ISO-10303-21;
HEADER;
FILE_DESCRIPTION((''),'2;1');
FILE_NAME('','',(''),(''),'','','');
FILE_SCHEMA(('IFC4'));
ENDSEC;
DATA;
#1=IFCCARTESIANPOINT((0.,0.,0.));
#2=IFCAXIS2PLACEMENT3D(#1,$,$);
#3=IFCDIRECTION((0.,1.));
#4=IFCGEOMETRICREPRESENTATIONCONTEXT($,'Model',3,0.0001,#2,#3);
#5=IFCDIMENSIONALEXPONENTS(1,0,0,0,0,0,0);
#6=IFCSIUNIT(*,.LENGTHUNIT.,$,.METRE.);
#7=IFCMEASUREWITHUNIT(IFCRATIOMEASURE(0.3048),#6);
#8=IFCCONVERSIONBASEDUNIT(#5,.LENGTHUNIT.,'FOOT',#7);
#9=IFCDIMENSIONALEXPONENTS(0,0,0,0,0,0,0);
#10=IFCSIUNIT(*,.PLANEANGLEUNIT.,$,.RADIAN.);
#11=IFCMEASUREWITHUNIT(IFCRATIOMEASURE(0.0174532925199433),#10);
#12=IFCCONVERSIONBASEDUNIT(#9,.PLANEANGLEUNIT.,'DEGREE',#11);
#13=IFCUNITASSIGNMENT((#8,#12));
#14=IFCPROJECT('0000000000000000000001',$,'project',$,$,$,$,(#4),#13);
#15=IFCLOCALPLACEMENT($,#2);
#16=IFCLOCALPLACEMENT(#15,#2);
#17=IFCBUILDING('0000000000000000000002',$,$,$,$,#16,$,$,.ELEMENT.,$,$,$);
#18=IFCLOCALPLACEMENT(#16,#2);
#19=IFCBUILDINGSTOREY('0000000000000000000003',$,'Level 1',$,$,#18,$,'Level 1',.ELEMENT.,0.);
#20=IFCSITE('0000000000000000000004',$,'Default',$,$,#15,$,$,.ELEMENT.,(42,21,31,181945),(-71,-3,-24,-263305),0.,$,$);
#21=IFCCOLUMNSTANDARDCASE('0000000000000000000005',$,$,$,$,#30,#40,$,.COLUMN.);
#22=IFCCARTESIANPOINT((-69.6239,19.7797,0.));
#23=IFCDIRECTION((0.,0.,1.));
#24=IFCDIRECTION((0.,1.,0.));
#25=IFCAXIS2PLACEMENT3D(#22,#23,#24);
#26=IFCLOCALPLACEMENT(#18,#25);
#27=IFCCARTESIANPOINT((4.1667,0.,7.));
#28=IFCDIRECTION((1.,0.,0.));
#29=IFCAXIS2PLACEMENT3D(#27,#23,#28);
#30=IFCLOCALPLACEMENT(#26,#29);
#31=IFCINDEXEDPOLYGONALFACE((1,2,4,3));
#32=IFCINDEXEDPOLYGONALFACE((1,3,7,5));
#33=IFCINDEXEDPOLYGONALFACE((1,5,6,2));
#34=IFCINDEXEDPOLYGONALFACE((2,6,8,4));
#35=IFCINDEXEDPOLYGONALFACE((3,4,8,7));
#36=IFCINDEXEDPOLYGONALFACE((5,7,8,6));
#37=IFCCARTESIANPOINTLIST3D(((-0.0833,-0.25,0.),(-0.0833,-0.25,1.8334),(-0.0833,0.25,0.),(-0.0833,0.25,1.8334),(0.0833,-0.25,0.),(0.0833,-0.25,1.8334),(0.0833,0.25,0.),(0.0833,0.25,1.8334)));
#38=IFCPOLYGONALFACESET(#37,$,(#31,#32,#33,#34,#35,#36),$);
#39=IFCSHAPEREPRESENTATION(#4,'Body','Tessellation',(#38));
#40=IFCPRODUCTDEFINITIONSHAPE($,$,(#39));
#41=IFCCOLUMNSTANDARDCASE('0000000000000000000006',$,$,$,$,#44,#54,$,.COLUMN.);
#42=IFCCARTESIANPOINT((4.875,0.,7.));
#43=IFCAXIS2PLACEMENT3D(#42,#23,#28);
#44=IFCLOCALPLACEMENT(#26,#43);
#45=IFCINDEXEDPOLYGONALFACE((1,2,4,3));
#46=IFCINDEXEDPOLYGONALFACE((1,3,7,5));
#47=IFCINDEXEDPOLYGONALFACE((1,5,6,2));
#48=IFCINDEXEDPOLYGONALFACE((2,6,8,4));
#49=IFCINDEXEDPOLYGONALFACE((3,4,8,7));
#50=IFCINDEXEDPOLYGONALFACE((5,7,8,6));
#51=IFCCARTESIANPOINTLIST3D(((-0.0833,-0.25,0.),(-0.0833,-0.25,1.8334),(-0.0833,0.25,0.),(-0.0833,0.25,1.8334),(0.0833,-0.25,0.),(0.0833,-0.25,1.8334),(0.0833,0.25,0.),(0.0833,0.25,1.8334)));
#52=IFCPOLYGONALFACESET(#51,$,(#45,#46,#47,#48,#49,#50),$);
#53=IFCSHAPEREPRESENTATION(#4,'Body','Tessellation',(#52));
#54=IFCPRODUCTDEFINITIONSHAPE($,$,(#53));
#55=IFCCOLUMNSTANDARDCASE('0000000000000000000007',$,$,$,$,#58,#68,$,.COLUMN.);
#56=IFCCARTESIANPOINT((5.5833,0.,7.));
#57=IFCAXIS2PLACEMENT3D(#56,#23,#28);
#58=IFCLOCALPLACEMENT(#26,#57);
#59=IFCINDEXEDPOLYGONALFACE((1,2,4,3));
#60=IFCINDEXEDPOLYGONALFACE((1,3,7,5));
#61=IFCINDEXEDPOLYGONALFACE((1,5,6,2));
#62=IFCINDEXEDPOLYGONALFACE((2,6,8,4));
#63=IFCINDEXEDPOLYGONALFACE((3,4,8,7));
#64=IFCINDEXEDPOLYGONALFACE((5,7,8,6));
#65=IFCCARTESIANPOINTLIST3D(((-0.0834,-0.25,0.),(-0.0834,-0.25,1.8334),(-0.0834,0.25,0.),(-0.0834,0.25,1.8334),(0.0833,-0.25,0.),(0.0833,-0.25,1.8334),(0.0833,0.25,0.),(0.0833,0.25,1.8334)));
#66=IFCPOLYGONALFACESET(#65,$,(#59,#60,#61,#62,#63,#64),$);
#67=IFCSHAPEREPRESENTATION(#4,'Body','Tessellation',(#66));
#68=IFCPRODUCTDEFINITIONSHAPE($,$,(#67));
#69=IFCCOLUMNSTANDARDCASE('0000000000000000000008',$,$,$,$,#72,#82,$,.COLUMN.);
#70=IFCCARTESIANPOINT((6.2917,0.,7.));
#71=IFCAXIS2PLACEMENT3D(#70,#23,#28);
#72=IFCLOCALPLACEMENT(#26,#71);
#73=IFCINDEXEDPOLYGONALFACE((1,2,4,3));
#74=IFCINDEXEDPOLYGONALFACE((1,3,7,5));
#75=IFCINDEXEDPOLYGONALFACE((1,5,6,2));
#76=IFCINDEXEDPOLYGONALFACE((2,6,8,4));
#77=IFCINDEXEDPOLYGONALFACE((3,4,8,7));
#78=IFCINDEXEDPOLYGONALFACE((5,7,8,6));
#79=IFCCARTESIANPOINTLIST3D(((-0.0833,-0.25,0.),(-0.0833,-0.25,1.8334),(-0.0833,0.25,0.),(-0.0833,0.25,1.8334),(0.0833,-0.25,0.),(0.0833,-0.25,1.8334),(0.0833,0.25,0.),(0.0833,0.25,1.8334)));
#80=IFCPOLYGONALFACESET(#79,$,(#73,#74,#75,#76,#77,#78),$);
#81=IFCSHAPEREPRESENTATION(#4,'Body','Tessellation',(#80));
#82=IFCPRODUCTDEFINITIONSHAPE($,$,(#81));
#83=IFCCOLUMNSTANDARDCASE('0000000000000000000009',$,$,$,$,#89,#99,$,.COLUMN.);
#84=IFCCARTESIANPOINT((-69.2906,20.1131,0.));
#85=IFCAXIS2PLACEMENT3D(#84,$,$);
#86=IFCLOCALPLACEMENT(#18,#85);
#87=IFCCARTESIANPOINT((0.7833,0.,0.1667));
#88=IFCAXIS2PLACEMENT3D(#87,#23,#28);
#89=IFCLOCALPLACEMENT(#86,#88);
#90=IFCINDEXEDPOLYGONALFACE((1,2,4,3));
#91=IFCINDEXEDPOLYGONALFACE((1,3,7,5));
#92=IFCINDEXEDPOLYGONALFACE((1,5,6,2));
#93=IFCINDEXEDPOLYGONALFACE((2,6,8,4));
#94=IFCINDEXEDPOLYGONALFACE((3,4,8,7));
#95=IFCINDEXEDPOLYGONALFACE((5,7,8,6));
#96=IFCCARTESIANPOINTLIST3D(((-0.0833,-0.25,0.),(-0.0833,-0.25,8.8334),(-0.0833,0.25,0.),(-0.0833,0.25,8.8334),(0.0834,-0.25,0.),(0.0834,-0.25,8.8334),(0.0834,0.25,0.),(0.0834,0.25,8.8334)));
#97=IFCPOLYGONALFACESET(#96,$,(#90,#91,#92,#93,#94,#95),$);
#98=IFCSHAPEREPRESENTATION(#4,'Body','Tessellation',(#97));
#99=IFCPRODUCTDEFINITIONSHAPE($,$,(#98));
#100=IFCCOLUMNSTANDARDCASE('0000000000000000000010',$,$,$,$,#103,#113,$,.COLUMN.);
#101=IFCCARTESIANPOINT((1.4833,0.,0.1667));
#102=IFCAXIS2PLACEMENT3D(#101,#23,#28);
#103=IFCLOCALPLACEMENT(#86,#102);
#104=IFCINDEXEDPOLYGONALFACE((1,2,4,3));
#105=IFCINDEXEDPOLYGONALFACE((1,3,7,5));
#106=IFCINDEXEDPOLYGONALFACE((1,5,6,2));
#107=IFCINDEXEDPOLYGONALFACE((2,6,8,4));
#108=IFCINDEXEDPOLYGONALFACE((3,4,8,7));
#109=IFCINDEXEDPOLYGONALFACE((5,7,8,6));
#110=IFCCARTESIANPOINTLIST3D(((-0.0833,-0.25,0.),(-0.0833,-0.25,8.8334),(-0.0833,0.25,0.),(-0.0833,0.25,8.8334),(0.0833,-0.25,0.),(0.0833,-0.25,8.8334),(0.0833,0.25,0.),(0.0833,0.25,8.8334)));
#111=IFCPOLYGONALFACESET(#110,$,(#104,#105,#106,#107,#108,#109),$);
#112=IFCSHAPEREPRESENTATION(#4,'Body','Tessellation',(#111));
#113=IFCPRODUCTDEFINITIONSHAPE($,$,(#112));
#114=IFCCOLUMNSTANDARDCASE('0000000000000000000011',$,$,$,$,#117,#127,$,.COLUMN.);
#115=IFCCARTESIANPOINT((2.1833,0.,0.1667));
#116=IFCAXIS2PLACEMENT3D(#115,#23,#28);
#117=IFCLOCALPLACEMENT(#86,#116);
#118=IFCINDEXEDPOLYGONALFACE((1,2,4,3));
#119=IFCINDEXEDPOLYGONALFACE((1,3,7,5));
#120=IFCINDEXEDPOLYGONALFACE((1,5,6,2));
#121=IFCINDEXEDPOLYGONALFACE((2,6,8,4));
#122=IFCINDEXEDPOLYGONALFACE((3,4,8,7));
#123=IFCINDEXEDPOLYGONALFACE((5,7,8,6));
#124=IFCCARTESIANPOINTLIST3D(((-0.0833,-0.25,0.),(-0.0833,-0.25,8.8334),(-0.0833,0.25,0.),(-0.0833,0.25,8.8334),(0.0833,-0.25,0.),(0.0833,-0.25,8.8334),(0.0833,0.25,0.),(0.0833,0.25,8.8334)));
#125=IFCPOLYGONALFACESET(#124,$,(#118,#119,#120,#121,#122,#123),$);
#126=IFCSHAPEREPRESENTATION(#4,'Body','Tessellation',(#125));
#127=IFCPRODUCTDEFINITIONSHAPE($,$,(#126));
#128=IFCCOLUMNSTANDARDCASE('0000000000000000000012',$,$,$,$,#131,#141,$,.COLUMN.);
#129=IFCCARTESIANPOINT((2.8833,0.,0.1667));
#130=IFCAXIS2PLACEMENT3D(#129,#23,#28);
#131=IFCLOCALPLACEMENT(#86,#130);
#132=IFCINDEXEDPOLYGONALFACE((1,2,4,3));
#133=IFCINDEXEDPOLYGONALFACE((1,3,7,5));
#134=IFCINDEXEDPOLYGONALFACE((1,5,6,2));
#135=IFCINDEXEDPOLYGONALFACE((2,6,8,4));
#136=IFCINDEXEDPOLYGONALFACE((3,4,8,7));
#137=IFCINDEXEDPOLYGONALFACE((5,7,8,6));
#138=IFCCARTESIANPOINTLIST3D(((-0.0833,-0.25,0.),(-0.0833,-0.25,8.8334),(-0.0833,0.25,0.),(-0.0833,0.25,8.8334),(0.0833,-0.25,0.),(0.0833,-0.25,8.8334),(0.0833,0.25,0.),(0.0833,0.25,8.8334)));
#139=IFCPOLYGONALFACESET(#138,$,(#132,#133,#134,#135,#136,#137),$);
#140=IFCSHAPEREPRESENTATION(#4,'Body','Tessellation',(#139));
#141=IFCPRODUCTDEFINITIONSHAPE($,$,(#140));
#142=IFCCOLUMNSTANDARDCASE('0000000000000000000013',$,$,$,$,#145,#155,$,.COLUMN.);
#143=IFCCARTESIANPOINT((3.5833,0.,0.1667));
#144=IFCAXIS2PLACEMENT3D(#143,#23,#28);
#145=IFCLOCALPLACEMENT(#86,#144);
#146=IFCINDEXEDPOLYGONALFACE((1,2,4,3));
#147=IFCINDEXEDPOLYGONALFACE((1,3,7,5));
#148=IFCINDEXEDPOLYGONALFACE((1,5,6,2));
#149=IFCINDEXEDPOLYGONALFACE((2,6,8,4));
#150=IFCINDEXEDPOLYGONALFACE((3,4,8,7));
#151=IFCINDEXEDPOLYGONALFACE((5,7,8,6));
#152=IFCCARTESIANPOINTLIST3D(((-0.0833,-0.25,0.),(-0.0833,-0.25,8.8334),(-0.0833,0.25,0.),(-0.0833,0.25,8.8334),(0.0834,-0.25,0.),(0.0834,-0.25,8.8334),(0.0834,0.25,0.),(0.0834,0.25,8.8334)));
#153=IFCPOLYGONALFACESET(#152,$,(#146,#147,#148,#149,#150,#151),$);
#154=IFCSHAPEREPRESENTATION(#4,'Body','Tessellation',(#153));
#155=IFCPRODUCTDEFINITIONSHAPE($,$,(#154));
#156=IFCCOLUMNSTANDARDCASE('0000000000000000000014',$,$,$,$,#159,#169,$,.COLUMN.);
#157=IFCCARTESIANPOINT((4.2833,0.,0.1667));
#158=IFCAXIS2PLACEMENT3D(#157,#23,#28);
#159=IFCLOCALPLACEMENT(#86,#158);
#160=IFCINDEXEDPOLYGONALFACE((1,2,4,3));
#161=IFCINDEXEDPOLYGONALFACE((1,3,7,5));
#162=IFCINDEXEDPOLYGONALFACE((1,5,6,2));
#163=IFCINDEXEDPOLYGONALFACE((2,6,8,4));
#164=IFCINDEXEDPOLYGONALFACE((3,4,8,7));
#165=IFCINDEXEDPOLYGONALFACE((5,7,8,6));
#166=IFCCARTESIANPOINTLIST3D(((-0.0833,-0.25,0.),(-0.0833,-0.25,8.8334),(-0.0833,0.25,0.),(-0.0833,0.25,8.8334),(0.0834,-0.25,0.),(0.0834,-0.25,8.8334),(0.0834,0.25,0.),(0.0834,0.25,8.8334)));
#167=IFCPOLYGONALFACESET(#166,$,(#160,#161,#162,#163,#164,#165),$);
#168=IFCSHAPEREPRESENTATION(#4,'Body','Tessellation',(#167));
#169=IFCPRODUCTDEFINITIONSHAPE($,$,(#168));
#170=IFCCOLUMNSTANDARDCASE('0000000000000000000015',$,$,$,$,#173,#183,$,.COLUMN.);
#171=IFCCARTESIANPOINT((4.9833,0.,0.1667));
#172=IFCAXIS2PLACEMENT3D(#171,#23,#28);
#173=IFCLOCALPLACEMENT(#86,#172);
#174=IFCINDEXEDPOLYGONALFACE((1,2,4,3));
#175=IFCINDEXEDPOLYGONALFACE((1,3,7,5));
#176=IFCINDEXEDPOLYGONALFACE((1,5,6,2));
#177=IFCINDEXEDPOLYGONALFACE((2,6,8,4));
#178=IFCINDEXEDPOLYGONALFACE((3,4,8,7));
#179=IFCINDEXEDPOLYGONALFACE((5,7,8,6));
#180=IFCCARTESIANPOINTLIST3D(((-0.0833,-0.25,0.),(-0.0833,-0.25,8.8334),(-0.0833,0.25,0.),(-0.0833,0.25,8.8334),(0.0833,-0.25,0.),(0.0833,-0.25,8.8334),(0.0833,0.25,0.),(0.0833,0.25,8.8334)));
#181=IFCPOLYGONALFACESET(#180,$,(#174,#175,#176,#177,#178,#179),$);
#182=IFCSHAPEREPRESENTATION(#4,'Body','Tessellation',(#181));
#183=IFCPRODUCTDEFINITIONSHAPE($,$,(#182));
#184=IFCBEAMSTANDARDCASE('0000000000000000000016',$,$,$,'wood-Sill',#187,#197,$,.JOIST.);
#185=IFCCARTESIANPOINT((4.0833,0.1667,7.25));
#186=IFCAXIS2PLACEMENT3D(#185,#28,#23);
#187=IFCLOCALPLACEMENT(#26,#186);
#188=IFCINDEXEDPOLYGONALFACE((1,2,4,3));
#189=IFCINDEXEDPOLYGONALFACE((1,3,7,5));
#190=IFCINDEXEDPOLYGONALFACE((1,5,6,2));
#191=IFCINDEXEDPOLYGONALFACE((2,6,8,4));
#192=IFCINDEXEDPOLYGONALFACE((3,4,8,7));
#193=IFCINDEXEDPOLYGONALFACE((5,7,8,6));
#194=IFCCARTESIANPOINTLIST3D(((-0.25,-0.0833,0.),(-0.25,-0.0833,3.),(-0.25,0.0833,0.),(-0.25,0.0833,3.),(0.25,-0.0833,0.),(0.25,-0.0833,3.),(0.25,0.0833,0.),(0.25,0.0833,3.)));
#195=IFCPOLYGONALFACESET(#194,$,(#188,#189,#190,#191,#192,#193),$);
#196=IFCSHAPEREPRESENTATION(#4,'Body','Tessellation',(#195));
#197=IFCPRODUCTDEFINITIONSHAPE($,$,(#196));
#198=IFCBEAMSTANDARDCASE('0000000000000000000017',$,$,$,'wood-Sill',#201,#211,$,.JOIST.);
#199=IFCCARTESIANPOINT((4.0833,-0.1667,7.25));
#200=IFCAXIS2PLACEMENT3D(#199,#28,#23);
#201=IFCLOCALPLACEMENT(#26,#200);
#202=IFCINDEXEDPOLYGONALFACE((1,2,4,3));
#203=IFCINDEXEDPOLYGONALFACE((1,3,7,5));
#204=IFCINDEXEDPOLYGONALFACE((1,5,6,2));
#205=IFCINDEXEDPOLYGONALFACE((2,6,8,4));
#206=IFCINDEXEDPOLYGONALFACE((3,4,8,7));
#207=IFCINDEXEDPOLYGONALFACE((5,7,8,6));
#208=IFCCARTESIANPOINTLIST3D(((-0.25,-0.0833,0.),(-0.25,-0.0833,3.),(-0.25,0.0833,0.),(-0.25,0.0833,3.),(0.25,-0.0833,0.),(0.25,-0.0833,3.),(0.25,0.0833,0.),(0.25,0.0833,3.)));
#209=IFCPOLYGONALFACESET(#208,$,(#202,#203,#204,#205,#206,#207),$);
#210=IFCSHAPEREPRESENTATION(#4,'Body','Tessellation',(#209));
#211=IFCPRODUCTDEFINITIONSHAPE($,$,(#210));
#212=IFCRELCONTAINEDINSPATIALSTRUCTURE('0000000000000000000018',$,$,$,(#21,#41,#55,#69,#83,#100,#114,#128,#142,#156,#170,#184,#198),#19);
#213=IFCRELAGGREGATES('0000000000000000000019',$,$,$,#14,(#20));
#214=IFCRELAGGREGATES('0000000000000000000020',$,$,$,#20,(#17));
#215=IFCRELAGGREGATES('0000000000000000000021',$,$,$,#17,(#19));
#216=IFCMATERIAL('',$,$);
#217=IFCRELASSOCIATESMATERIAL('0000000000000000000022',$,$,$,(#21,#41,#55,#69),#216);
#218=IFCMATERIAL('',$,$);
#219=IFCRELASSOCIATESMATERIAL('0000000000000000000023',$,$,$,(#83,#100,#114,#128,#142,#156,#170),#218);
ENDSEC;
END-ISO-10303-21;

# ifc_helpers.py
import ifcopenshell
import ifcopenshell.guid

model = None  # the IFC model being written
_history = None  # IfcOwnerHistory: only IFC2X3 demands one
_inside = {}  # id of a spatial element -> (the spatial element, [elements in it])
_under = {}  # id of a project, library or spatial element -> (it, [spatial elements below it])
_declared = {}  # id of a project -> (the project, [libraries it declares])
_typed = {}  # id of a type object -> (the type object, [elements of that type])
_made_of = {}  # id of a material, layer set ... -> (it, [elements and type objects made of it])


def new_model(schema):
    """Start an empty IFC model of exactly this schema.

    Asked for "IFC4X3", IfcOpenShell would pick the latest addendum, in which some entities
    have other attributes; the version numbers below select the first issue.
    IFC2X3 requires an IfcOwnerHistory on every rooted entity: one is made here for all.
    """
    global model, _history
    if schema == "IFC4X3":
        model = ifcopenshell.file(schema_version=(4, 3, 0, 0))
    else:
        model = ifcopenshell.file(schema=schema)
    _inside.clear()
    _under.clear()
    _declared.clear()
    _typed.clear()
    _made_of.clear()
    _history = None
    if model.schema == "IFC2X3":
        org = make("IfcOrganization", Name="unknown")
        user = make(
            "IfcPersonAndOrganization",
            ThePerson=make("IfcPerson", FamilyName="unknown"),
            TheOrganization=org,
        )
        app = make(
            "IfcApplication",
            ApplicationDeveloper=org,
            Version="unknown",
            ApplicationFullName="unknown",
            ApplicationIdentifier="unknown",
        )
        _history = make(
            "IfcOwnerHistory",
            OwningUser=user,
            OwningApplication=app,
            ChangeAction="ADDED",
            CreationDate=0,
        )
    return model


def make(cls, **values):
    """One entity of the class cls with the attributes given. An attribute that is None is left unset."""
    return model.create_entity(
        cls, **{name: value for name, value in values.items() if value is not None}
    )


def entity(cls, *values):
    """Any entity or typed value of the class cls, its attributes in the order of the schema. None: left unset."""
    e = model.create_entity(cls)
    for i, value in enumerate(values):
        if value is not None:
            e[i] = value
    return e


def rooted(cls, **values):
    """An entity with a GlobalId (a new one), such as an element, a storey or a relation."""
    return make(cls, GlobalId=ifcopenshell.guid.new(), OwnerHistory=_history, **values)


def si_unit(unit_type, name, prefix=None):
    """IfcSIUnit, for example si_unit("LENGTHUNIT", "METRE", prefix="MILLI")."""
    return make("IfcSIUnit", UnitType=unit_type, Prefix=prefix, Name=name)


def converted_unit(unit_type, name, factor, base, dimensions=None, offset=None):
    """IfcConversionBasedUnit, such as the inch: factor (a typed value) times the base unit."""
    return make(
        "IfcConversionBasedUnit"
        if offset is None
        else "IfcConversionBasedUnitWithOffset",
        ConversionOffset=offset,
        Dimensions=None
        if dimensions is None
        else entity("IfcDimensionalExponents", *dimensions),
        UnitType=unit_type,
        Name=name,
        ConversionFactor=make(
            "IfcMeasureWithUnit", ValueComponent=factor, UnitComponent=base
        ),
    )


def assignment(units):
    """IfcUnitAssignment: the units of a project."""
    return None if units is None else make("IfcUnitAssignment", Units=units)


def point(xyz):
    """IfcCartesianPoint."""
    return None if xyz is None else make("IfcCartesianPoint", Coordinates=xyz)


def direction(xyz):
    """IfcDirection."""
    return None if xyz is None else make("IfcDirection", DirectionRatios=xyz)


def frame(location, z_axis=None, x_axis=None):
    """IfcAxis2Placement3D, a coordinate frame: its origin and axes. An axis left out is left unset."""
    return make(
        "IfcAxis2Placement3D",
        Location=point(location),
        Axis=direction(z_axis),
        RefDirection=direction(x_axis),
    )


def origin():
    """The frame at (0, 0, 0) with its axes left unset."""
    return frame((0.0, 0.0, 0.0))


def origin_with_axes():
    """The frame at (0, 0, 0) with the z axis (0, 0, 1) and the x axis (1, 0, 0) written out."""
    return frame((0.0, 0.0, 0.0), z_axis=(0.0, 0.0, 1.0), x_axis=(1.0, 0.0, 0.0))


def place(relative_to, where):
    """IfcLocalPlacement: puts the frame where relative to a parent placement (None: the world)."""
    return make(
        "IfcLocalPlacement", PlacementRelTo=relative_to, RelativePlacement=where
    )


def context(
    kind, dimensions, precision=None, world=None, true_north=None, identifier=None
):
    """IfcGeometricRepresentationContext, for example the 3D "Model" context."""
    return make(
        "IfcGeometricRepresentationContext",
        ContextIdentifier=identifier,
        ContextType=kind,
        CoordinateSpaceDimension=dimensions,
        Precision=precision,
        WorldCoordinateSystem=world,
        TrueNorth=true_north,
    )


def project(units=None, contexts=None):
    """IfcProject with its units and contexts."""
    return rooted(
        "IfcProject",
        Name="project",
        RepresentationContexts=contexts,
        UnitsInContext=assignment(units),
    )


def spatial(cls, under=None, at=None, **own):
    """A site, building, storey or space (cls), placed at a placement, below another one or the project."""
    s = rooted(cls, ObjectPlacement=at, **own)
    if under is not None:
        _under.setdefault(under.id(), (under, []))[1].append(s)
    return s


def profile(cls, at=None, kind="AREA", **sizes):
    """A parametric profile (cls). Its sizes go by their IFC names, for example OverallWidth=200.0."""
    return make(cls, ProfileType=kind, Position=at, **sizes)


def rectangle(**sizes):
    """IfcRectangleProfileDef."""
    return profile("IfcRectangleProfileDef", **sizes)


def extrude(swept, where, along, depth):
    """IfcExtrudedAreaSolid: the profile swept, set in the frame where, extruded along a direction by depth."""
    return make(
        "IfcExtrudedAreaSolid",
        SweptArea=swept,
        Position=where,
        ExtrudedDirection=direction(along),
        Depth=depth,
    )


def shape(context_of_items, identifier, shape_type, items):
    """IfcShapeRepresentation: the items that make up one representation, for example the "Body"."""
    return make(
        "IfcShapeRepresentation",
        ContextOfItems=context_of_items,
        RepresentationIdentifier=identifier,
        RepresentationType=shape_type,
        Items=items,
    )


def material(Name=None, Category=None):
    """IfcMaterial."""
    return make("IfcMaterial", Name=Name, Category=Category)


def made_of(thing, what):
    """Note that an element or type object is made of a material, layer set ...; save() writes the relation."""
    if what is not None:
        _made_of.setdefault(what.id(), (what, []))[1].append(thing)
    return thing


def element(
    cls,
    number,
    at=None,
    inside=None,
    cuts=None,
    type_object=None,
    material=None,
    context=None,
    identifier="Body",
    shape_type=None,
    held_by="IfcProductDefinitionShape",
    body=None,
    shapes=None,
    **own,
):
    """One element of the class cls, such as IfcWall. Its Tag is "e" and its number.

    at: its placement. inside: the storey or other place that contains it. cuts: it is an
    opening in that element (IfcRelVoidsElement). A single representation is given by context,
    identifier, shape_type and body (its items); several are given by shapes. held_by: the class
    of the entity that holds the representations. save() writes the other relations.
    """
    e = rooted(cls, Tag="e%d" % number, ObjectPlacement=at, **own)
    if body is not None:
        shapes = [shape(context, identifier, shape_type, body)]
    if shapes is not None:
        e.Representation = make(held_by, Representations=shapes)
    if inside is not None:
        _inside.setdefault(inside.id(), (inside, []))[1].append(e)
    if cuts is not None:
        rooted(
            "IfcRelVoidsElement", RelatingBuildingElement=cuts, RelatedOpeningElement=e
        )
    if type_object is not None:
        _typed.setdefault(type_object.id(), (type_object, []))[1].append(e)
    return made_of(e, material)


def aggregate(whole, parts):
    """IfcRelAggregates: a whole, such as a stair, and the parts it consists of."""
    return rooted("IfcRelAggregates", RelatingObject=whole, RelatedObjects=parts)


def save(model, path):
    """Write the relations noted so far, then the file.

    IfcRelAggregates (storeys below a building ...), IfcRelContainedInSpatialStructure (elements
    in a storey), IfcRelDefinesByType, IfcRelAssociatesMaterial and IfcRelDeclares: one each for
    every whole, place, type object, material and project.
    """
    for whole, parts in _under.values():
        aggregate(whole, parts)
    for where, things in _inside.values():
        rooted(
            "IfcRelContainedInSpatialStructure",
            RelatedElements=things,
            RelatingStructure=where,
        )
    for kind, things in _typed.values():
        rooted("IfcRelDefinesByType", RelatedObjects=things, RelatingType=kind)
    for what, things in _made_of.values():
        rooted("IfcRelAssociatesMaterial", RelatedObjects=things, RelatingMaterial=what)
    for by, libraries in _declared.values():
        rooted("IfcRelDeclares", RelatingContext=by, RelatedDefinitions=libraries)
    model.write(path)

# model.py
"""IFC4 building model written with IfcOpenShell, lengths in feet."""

from ifc_helpers import new_model, entity, si_unit, converted_unit, direction, frame, origin, origin_with_axes, place, context, project, spatial, rectangle, extrude, material, element, save


model = new_model("IFC4")

# Units and contexts
model_context = context("Model", 3, precision=0.0001, world=origin(), true_north=direction((0.0, 1.0)))
ifc_project = project(units=[converted_unit("LENGTHUNIT", "FOOT", entity("IfcRatioMeasure", 0.3048), si_unit("LENGTHUNIT", "METRE"), dimensions=[1, 0, 0, 0, 0, 0, 0]), converted_unit("PLANEANGLEUNIT", "DEGREE", entity("IfcRatioMeasure", 0.0174532925199433), si_unit("PLANEANGLEUNIT", "RADIAN"), dimensions=[0, 0, 0, 0, 0, 0, 0])], contexts=[model_context])

# Site, building, storey
site_placement = place(None, origin())
site = spatial("IfcSite", under=ifc_project, at=site_placement, Name="Default", CompositionType="ELEMENT", RefLatitude=(42, 21, 31, 181945), RefLongitude=(-71, -3, -24, -263305), RefElevation=0.0)
building_placement = place(site_placement, origin())
building = spatial("IfcBuilding", under=site, at=building_placement, CompositionType="ELEMENT")
storey_placement = place(building_placement, origin())
storey = spatial("IfcBuildingStorey", under=building, at=storey_placement, Name="Level 1", LongName="Level 1", CompositionType="ELEMENT", Elevation=0.0)

# Columns
ifc_material_1 = material(Name="")
placement_1 = place(storey_placement, frame((-69.6239, 19.7797, 0.0), z_axis=(0.0, 0.0, 1.0), x_axis=(0.0, 1.0, 0.0)))
ifc_material_2 = material(Name="")
for number, where, z_axis, x_axis in (
    (1, (4.1667, 0.0, 7.0), (0.0, 0.0, 1.0), (1.0, 0.0, 0.0)),
    (2, (4.875, 0.0, 7.0), (0.0, 0.0, 1.0), (1.0, 0.0, 0.0)),
    (3, (5.5833, 0.0, 7.0), (0.0, 0.0, 1.0), (1.0, 0.0, 0.0)),
    (4, (6.2917, 0.0, 7.0), (0.0, 0.0, 1.0), (1.0, 0.0, 0.0)),
):
    element("IfcColumnStandardCase", number, at=place(placement_1, frame(where, z_axis=z_axis, x_axis=x_axis)), inside=storey, material=ifc_material_2, PredefinedType="COLUMN", context=model_context, shape_type="SweptSolid", body=[
        extrude(rectangle(XDim=0.1667, YDim=0.5), origin(), (0.0, 0.0, 1.0), 1.8334),
    ])
placement_2 = place(storey_placement, frame((-69.2906, 20.1131, 0.0)))
for number, where, z_axis, x_axis in (
    (5, (0.7833, 0.0, 0.1667), (0.0, 0.0, 1.0), (1.0, 0.0, 0.0)),
    (6, (1.4833, 0.0, 0.1667), (0.0, 0.0, 1.0), (1.0, 0.0, 0.0)),
    (7, (2.1833, 0.0, 0.1667), (0.0, 0.0, 1.0), (1.0, 0.0, 0.0)),
    (8, (2.8833, 0.0, 0.1667), (0.0, 0.0, 1.0), (1.0, 0.0, 0.0)),
    (9, (3.5833, 0.0, 0.1667), (0.0, 0.0, 1.0), (1.0, 0.0, 0.0)),
    (10, (4.2833, 0.0, 0.1667), (0.0, 0.0, 1.0), (1.0, 0.0, 0.0)),
    (11, (4.9833, 0.0, 0.1667), (0.0, 0.0, 1.0), (1.0, 0.0, 0.0)),
):
    element("IfcColumnStandardCase", number, at=place(placement_2, frame(where, z_axis=z_axis, x_axis=x_axis)), inside=storey, material=ifc_material_1, PredefinedType="COLUMN", context=model_context, shape_type="SweptSolid", body=[
        extrude(rectangle(XDim=0.1667, YDim=0.5), origin(), (0.0, 0.0, 1.0), 8.8334),
    ])

# Beams
for number, where, z_axis, x_axis in (
    (12, (4.0833, 0.1667, 7.25), (1.0, 0.0, 0.0), (0.0, 0.0, 1.0)),
    (13, (4.0833, -0.1667, 7.25), (1.0, 0.0, 0.0), (0.0, 0.0, 1.0)),
):
    element("IfcBeamStandardCase", number, at=place(placement_1, frame(where, z_axis=z_axis, x_axis=x_axis)), inside=storey, ObjectType="wood-Sill", PredefinedType="JOIST", context=model_context, shape_type="SweptSolid", body=[
        extrude(rectangle(XDim=0.5, YDim=0.1667), origin_with_axes(), (0.0, 0.0, 1.0), 3.0),
    ])

save(model, "model.ifc")
